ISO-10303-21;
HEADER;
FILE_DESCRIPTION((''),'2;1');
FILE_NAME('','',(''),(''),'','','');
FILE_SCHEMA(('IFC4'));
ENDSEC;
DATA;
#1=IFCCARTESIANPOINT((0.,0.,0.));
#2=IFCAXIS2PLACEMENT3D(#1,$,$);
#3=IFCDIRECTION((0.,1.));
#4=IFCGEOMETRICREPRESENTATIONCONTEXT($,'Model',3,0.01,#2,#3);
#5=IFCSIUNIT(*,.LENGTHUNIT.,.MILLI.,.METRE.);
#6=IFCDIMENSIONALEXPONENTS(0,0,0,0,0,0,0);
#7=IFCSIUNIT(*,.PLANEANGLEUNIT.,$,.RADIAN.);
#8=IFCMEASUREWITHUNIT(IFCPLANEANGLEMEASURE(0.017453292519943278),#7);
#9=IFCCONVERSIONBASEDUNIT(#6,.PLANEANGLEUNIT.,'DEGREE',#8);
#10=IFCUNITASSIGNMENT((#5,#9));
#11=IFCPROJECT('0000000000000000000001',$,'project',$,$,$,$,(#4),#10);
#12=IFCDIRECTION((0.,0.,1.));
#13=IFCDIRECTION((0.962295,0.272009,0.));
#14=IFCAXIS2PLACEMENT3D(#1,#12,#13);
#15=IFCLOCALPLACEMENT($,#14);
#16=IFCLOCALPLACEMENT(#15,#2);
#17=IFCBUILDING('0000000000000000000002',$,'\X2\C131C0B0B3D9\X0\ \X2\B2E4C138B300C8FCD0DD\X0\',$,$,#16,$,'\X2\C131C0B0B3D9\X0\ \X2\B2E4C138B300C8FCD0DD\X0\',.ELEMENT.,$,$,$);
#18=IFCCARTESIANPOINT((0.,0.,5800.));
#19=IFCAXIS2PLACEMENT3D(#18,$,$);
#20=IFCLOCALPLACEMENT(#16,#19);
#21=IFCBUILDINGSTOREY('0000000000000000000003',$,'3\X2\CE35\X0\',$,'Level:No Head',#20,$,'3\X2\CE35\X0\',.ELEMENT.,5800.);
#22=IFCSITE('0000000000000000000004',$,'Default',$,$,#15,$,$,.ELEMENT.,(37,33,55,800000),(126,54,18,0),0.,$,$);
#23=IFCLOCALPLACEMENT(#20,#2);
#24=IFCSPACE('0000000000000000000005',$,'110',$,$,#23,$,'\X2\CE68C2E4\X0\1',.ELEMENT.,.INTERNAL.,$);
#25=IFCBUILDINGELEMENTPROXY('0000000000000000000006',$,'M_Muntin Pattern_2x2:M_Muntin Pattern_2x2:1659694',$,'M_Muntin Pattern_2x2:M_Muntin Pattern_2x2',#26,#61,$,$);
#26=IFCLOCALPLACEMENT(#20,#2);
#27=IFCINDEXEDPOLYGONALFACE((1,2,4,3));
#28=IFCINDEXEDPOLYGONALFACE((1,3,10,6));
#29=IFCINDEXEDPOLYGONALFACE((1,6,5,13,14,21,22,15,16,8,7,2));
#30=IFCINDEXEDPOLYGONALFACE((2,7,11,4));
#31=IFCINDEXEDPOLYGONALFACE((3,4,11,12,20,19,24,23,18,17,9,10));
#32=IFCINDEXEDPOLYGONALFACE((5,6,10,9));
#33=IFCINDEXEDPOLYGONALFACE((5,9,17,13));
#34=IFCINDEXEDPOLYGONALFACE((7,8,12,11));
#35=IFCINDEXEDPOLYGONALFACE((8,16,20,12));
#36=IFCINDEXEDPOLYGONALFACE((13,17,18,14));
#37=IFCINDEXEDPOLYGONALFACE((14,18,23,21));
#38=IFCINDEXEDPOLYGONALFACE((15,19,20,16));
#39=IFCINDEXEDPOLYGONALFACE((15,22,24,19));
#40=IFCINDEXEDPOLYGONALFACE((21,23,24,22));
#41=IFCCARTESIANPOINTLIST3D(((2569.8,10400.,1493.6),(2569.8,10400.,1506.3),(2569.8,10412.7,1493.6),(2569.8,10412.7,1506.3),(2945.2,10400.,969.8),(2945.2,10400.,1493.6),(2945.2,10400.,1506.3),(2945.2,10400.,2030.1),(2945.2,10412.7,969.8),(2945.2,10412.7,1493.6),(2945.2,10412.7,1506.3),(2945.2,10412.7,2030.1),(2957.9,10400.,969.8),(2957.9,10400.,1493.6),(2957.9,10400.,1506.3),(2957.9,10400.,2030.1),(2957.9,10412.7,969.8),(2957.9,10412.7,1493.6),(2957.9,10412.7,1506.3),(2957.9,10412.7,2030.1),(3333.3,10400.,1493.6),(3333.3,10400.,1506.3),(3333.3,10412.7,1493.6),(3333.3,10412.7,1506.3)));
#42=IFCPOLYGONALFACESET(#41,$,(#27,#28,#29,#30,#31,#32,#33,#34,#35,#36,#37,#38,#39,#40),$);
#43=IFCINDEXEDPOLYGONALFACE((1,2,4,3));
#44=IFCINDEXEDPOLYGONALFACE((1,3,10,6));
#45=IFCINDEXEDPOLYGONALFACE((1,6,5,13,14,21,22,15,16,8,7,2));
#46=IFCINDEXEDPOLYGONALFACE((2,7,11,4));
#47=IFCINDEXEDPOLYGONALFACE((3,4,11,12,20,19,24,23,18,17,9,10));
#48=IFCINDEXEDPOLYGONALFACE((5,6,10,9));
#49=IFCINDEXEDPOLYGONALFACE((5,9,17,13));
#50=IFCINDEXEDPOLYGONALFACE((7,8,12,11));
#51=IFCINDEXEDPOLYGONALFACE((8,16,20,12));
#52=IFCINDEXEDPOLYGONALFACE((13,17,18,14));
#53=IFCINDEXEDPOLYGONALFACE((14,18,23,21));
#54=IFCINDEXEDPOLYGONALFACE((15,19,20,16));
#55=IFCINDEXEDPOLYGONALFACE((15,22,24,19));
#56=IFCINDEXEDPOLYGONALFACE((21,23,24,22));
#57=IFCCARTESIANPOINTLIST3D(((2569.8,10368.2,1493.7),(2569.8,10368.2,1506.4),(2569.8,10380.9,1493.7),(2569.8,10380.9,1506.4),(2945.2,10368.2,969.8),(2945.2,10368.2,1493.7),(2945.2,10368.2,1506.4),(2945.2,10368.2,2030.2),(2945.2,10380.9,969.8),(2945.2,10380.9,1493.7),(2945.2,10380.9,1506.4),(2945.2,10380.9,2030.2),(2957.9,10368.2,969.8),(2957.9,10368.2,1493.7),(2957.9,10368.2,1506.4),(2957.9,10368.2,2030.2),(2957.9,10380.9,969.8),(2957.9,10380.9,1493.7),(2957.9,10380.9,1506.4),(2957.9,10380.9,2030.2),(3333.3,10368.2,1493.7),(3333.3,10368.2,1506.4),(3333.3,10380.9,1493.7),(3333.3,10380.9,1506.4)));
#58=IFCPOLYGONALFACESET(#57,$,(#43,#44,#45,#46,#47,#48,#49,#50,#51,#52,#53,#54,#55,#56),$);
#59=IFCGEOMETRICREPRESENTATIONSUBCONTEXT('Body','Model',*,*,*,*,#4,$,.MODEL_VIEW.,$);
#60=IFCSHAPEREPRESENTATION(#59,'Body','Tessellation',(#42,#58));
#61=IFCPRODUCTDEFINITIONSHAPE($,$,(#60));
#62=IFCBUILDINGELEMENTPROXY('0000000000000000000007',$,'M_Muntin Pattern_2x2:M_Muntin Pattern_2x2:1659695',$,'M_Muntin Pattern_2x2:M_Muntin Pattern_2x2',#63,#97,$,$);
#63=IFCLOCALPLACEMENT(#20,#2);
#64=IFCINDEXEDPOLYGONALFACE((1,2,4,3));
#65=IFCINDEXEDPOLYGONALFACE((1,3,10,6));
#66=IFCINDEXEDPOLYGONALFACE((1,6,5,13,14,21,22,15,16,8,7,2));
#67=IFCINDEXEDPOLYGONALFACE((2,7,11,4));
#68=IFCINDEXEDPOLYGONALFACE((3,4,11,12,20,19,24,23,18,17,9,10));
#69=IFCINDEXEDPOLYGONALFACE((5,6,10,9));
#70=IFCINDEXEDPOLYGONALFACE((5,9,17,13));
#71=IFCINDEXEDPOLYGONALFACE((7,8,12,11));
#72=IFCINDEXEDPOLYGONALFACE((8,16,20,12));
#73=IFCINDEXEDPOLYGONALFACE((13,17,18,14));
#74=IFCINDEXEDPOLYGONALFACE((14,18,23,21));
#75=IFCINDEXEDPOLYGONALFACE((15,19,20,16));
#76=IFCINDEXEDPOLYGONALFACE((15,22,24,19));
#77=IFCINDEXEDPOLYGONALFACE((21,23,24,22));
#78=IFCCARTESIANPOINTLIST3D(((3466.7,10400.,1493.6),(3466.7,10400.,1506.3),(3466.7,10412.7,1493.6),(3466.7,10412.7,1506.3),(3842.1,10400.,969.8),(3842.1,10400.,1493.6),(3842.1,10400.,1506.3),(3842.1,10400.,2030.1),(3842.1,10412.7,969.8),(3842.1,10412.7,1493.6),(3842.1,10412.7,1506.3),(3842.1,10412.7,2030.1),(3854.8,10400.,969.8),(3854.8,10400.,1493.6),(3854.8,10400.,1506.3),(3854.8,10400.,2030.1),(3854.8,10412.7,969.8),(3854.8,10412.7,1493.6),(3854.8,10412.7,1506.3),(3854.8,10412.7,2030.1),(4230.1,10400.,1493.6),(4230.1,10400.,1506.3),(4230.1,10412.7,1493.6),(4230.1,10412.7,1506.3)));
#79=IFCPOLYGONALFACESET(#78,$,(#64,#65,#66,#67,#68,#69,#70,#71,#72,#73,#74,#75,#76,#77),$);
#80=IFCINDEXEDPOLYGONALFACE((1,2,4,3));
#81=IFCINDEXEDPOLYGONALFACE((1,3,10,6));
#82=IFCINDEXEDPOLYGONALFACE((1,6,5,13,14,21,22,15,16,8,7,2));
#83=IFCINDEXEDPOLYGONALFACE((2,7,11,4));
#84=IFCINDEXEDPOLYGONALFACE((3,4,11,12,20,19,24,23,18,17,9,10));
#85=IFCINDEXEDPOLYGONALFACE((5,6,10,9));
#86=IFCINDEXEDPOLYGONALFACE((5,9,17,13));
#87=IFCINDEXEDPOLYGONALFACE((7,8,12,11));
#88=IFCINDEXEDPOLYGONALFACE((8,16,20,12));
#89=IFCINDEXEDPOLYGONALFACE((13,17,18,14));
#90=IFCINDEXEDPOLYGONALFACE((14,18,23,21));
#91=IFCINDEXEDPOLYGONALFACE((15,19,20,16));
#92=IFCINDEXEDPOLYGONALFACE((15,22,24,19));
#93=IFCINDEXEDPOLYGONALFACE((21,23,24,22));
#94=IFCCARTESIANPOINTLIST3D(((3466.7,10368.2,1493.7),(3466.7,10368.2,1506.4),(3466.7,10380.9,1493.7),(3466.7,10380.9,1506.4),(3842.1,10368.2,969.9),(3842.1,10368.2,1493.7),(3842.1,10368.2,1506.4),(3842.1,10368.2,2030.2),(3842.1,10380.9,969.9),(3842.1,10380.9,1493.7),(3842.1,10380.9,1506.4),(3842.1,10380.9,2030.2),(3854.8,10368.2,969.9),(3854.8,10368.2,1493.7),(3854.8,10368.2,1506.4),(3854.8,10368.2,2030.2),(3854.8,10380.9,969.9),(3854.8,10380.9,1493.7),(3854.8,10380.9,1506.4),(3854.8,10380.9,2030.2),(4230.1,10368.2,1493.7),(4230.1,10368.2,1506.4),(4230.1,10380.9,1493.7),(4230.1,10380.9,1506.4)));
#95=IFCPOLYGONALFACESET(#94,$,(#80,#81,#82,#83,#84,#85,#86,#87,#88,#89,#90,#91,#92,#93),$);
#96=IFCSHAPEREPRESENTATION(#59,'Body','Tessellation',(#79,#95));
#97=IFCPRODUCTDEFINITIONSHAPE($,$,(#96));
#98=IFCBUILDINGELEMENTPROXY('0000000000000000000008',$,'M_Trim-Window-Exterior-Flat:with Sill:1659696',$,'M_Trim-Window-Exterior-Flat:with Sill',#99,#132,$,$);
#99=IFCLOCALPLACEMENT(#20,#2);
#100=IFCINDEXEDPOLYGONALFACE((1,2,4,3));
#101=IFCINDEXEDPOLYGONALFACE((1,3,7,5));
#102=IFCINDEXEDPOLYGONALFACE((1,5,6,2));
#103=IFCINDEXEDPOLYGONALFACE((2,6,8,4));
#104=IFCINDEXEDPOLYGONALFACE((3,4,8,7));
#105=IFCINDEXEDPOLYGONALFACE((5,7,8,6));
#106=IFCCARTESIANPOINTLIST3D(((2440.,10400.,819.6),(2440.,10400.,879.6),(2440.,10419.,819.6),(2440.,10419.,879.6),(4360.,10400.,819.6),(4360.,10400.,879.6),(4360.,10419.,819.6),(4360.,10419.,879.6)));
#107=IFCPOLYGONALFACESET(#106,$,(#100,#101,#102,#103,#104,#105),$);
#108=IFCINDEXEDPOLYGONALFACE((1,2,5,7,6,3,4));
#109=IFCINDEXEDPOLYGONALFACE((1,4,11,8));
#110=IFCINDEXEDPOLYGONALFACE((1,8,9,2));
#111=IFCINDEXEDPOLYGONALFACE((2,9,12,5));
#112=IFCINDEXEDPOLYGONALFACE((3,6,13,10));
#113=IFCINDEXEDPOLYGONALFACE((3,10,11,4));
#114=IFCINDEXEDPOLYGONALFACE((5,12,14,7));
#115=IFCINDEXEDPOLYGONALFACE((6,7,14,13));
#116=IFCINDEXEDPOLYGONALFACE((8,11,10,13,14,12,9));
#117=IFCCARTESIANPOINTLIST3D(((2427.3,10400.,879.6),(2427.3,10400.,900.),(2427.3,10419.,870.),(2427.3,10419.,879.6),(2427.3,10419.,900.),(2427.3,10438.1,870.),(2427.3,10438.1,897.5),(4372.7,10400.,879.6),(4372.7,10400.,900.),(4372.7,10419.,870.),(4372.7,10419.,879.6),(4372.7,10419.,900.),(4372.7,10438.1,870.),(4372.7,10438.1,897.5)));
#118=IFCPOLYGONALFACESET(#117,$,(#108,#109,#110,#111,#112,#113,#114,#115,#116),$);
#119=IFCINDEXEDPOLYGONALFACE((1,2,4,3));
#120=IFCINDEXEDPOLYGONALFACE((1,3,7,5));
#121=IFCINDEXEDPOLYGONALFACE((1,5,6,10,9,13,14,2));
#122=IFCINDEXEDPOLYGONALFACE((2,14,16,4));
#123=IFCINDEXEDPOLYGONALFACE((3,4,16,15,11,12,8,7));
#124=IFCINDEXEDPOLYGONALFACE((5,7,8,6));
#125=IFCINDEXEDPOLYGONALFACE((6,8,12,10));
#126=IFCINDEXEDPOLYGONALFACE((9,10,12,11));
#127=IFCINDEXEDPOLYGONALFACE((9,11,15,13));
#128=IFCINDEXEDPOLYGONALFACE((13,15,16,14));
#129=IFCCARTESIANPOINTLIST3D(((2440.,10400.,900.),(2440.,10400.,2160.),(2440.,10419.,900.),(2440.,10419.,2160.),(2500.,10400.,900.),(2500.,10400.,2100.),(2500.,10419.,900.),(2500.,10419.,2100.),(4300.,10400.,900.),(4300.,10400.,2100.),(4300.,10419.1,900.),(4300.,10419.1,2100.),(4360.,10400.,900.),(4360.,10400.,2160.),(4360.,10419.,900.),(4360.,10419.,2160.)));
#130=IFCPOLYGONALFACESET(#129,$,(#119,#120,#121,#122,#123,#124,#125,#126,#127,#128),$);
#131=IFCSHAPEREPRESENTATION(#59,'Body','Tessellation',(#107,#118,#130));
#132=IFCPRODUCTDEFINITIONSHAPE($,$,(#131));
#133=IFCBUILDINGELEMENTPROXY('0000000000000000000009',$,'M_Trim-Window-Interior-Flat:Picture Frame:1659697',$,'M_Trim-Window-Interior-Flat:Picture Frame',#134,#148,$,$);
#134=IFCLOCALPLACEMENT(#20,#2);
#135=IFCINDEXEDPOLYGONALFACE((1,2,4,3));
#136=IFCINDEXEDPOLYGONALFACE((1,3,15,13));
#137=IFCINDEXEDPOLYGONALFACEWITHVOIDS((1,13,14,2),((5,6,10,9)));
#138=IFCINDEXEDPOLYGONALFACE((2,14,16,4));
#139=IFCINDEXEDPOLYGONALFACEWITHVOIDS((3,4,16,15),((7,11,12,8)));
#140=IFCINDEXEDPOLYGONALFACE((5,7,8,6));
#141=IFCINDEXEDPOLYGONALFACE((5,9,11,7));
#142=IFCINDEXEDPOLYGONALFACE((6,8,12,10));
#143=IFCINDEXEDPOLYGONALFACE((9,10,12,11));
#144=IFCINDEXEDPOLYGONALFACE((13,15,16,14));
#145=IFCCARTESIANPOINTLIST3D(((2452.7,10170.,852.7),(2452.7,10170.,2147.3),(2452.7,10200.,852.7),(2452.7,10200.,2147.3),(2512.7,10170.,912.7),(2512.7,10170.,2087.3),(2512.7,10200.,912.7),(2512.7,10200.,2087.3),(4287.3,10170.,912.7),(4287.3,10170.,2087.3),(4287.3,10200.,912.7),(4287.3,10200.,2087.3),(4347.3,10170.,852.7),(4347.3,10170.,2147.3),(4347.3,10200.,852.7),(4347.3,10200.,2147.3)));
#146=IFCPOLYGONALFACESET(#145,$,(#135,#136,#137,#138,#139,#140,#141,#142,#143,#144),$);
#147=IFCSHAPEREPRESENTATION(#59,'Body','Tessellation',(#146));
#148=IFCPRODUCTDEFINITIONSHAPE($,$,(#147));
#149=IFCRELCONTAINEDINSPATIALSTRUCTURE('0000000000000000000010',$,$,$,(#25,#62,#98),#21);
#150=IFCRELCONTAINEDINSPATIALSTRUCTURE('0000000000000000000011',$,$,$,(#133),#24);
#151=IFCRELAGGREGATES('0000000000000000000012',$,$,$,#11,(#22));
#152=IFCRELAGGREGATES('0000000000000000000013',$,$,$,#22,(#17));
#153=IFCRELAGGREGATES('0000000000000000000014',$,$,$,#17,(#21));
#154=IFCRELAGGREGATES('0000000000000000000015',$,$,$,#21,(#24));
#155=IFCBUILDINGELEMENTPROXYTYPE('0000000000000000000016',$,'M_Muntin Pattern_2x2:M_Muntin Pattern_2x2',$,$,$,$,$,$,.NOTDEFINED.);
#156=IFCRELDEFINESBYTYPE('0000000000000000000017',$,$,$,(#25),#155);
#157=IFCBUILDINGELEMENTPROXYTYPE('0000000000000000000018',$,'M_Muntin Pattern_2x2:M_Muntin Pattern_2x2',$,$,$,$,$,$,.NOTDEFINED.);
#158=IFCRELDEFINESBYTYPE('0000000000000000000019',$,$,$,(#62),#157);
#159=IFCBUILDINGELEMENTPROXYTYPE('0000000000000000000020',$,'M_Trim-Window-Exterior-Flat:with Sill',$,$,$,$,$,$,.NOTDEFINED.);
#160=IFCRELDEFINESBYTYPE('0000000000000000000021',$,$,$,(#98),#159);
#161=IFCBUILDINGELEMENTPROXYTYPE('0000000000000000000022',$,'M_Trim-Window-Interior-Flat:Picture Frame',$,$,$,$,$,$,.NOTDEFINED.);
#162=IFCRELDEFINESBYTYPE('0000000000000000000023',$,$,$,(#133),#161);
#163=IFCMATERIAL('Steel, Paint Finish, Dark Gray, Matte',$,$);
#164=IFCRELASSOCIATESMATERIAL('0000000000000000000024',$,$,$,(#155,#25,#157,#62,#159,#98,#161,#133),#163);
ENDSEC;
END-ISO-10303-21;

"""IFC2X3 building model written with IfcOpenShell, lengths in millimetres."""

from ifc_helpers import new_model, entity, si_unit, converted_unit, direction, frame, frame_2d, origin, place, context, subcontext, project, spatial, polyline, rectangle, outline, extrude, source, transform, mapped, material, type_object, type_shapes, element, save


model = new_model("IFC2X3")

# Units and contexts
model_context = context("Model", 3, precision=0.01, world=origin(), true_north=direction((0.0, 1.0)))
body_context = subcontext(model_context, "Body", "Model", "MODEL_VIEW")
ifc_project = project(units=[si_unit("LENGTHUNIT", "METRE", prefix="MILLI"), converted_unit("PLANEANGLEUNIT", "DEGREE", entity("IfcPlaneAngleMeasure", 0.017453292519943278), si_unit("PLANEANGLEUNIT", "RADIAN"), dimensions=[0, 0, 0, 0, 0, 0, 0])], contexts=[model_context])

# Site, building, storey
site_placement = place(None, frame((0.0, 0.0, 0.0), z_axis=(0.0, 0.0, 1.0), x_axis=(0.962295, 0.272009, 0.0)))
site = spatial("IfcSite", under=ifc_project, at=site_placement, Name="Default", CompositionType="ELEMENT", RefLatitude=(37, 33, 55, 800000), RefLongitude=(126, 54, 18, 0), RefElevation=0.0)
building_placement = place(site_placement, origin())
building = spatial("IfcBuilding", under=site, at=building_placement, Name="성산동 다세대주택", LongName="성산동 다세대주택", CompositionType="ELEMENT")
storey_placement = place(building_placement, frame((0.0, 0.0, 5800.0)))
storey = spatial("IfcBuildingStorey", under=building, at=storey_placement, Name="3층", ObjectType="Level:No Head", LongName="3층", CompositionType="ELEMENT", Elevation=5800.0)

# Shared definitions
space_1_placement = place(storey_placement, origin())
space_1 = spatial("IfcSpace", under=storey, at=space_1_placement, Name="110", LongName="침실1", CompositionType="ELEMENT", InteriorOrExteriorSpace="INTERNAL")

# Building element proxies
ifc_material_1 = material(Name="Steel, Paint Finish, Dark Gray, Matte")
building_element_proxy_type_1 = type_object("IfcBuildingElementProxyType", Name="M_Muntin Pattern_2x2:M_Muntin Pattern_2x2", PredefinedType="NOTDEFINED", material=ifc_material_1)
shared_shape_1 = source(origin(), body_context, "Body", "SweptSolid", [
    extrude(outline(polyline([(6.4, -6.4), (530.1, -6.4), (530.1, 6.3), (6.4, 6.3), (6.4, 381.7), (-6.3, 381.7), (-6.3, 6.3), (-530.2, 6.3), (-530.2, -6.4), (-6.3, -6.4), (-6.3, -381.7), (6.4, -381.7), (6.4, -6.4)])), frame((0.0, 9.5, 530.1), z_axis=(0.0, 1.0, 0.0), x_axis=(0.0, 0.0, 1.0)), (0.0, 0.0, 1.0), 12.7),
    extrude(outline(polyline([(6.4, -6.4), (530.2, -6.4), (530.2, 6.3), (6.4, 6.3), (6.4, 381.7), (-6.3, 381.7), (-6.3, 6.3), (-530.2, 6.3), (-530.2, -6.4), (-6.3, -6.4), (-6.3, -381.7), (6.4, -381.7), (6.4, -6.4)])), frame((0.0, -22.2, 530.2), z_axis=(0.0, 1.0, 0.0), x_axis=(0.0, 0.0, 1.0)), (0.0, 0.0, 1.0), 12.7),
])
type_shapes(building_element_proxy_type_1, [shared_shape_1])
proxy_1_placement = place(storey_placement, frame((2951.6, 10390.5, 969.8)))
element("IfcBuildingElementProxy", 1, at=proxy_1_placement, inside=storey, type_object=building_element_proxy_type_1, material=ifc_material_1, Name="M_Muntin Pattern_2x2:M_Muntin Pattern_2x2:1659694", ObjectType="M_Muntin Pattern_2x2:M_Muntin Pattern_2x2", context=body_context, shape_type="MappedRepresentation", body=[
    mapped(shared_shape_1, transform((0.0, 0.0, 0.0), scale=1.0)),
])
building_element_proxy_type_2 = type_object("IfcBuildingElementProxyType", Name="M_Muntin Pattern_2x2:M_Muntin Pattern_2x2", PredefinedType="NOTDEFINED", material=ifc_material_1)
shared_shape_2 = source(origin(), body_context, "Body", "SweptSolid", [
    extrude(outline(polyline([(6.4, -6.4), (530.1, -6.4), (530.1, 6.3), (6.4, 6.3), (6.4, 381.7), (-6.3, 381.7), (-6.3, 6.3), (-530.2, 6.3), (-530.2, -6.4), (-6.3, -6.4), (-6.3, -381.7), (6.4, -381.7), (6.4, -6.4)])), frame((0.0, -22.2, 530.1), z_axis=(0.0, 1.0, 0.0), x_axis=(0.0, 0.0, 1.0)), (0.0, 0.0, 1.0), 12.7),
    extrude(outline(polyline([(6.4, -6.4), (530.2, -6.4), (530.2, 6.3), (6.4, 6.3), (6.4, 381.7), (-6.3, 381.7), (-6.3, 6.3), (-530.2, 6.3), (-530.2, -6.4), (-6.3, -6.4), (-6.3, -381.7), (6.4, -381.7), (6.4, -6.4)])), frame((0.0, 9.5, 530.2), z_axis=(0.0, 1.0, 0.0), x_axis=(0.0, 0.0, 1.0)), (0.0, 0.0, 1.0), 12.7),
])
type_shapes(building_element_proxy_type_2, [shared_shape_2])
proxy_2_placement = place(storey_placement, frame((3848.4, 10390.5, 969.9), z_axis=(0.0, 0.0, 1.0), x_axis=(-1.0, 0.0, 0.0)))
element("IfcBuildingElementProxy", 2, at=proxy_2_placement, inside=storey, type_object=building_element_proxy_type_2, material=ifc_material_1, Name="M_Muntin Pattern_2x2:M_Muntin Pattern_2x2:1659695", ObjectType="M_Muntin Pattern_2x2:M_Muntin Pattern_2x2", context=body_context, shape_type="MappedRepresentation", body=[
    mapped(shared_shape_2, transform((0.0, 0.0, 0.0), scale=1.0)),
])
building_element_proxy_type_3 = type_object("IfcBuildingElementProxyType", Name="M_Trim-Window-Exterior-Flat:with Sill", PredefinedType="NOTDEFINED", material=ifc_material_1)
shared_shape_3 = source(origin(), body_context, "Body", "SweptSolid", [
    extrude(rectangle(XDim=1920.0, YDim=60.0, at=frame_2d((0.0, 0.0), x_axis=(1.0, 0.0))), frame((0.0, -1250.4, 0.0), z_axis=(0.0, 0.0, 1.0), x_axis=(-1.0, 0.0, 0.0)), (0.0, 0.0, 1.0), 19.0),
    extrude(outline(polyline([(-19.0, -15.2), (0.0, -15.2), (0.0, -5.7), (19.0, -5.7), (19.0, 14.8), (0.0, 14.8), (-19.0, 12.3), (-19.0, -15.2)])), frame((-972.7, -1214.8, 19.0), z_axis=(1.0, 0.0, 0.0), x_axis=(0.0, 0.0, -1.0)), (0.0, 0.0, 1.0), 1945.4),
    extrude(outline(polyline([(-645.0, -960.0), (615.0, -960.0), (615.0, -900.0), (-585.0, -900.0), (-585.0, 900.0), (615.0, 900.0), (615.0, 960.0), (-645.0, 960.0), (-645.0, -960.0)])), frame((0.0, -585.0, 0.0), z_axis=(0.0, 0.0, 1.0), x_axis=(0.0, -1.0, 0.0)), (0.0, 0.0, 1.0), 19.0),
])
type_shapes(building_element_proxy_type_3, [shared_shape_3])
proxy_3_placement = place(storey_placement, frame((3400.0, 10400.0, 2100.0), z_axis=(0.0, 1.0, 0.0), x_axis=(-1.0, 0.0, 0.0)))
element("IfcBuildingElementProxy", 3, at=proxy_3_placement, inside=storey, type_object=building_element_proxy_type_3, material=ifc_material_1, Name="M_Trim-Window-Exterior-Flat:with Sill:1659696", ObjectType="M_Trim-Window-Exterior-Flat:with Sill", context=body_context, shape_type="MappedRepresentation", body=[
    mapped(shared_shape_3, transform((0.0, 0.0, 0.0), scale=1.0)),
])
building_element_proxy_type_4 = type_object("IfcBuildingElementProxyType", Name="M_Trim-Window-Interior-Flat:Picture Frame", PredefinedType="NOTDEFINED", material=ifc_material_1)
shared_shape_4 = source(origin(), body_context, "Body", "SweptSolid", [
    extrude(outline(polyline([(-947.3, -647.3), (947.3, -647.3), (947.3, 647.3), (-947.3, 647.3), (-947.3, -647.3)]), holes=[polyline([(-887.3, -587.3), (-887.3, 587.3), (887.3, 587.3), (887.3, -587.3), (-887.3, -587.3)])]), frame((0.0, -600.0, 0.0), z_axis=(0.0, 0.0, 1.0), x_axis=(-1.0, 0.0, 0.0)), (0.0, 0.0, 1.0), 30.0),
])
type_shapes(building_element_proxy_type_4, [shared_shape_4])
proxy_4_placement = place(space_1_placement, frame((3400.0, 10200.0, 2100.0), z_axis=(0.0, -1.0, 0.0), x_axis=(1.0, 0.0, 0.0)))
element("IfcBuildingElementProxy", 4, at=proxy_4_placement, inside=space_1, type_object=building_element_proxy_type_4, material=ifc_material_1, Name="M_Trim-Window-Interior-Flat:Picture Frame:1659697", ObjectType="M_Trim-Window-Interior-Flat:Picture Frame", context=body_context, shape_type="MappedRepresentation", body=[
    mapped(shared_shape_4, transform((0.0, 0.0, 0.0), scale=1.0)),
])

save(model, "model.ifc")
